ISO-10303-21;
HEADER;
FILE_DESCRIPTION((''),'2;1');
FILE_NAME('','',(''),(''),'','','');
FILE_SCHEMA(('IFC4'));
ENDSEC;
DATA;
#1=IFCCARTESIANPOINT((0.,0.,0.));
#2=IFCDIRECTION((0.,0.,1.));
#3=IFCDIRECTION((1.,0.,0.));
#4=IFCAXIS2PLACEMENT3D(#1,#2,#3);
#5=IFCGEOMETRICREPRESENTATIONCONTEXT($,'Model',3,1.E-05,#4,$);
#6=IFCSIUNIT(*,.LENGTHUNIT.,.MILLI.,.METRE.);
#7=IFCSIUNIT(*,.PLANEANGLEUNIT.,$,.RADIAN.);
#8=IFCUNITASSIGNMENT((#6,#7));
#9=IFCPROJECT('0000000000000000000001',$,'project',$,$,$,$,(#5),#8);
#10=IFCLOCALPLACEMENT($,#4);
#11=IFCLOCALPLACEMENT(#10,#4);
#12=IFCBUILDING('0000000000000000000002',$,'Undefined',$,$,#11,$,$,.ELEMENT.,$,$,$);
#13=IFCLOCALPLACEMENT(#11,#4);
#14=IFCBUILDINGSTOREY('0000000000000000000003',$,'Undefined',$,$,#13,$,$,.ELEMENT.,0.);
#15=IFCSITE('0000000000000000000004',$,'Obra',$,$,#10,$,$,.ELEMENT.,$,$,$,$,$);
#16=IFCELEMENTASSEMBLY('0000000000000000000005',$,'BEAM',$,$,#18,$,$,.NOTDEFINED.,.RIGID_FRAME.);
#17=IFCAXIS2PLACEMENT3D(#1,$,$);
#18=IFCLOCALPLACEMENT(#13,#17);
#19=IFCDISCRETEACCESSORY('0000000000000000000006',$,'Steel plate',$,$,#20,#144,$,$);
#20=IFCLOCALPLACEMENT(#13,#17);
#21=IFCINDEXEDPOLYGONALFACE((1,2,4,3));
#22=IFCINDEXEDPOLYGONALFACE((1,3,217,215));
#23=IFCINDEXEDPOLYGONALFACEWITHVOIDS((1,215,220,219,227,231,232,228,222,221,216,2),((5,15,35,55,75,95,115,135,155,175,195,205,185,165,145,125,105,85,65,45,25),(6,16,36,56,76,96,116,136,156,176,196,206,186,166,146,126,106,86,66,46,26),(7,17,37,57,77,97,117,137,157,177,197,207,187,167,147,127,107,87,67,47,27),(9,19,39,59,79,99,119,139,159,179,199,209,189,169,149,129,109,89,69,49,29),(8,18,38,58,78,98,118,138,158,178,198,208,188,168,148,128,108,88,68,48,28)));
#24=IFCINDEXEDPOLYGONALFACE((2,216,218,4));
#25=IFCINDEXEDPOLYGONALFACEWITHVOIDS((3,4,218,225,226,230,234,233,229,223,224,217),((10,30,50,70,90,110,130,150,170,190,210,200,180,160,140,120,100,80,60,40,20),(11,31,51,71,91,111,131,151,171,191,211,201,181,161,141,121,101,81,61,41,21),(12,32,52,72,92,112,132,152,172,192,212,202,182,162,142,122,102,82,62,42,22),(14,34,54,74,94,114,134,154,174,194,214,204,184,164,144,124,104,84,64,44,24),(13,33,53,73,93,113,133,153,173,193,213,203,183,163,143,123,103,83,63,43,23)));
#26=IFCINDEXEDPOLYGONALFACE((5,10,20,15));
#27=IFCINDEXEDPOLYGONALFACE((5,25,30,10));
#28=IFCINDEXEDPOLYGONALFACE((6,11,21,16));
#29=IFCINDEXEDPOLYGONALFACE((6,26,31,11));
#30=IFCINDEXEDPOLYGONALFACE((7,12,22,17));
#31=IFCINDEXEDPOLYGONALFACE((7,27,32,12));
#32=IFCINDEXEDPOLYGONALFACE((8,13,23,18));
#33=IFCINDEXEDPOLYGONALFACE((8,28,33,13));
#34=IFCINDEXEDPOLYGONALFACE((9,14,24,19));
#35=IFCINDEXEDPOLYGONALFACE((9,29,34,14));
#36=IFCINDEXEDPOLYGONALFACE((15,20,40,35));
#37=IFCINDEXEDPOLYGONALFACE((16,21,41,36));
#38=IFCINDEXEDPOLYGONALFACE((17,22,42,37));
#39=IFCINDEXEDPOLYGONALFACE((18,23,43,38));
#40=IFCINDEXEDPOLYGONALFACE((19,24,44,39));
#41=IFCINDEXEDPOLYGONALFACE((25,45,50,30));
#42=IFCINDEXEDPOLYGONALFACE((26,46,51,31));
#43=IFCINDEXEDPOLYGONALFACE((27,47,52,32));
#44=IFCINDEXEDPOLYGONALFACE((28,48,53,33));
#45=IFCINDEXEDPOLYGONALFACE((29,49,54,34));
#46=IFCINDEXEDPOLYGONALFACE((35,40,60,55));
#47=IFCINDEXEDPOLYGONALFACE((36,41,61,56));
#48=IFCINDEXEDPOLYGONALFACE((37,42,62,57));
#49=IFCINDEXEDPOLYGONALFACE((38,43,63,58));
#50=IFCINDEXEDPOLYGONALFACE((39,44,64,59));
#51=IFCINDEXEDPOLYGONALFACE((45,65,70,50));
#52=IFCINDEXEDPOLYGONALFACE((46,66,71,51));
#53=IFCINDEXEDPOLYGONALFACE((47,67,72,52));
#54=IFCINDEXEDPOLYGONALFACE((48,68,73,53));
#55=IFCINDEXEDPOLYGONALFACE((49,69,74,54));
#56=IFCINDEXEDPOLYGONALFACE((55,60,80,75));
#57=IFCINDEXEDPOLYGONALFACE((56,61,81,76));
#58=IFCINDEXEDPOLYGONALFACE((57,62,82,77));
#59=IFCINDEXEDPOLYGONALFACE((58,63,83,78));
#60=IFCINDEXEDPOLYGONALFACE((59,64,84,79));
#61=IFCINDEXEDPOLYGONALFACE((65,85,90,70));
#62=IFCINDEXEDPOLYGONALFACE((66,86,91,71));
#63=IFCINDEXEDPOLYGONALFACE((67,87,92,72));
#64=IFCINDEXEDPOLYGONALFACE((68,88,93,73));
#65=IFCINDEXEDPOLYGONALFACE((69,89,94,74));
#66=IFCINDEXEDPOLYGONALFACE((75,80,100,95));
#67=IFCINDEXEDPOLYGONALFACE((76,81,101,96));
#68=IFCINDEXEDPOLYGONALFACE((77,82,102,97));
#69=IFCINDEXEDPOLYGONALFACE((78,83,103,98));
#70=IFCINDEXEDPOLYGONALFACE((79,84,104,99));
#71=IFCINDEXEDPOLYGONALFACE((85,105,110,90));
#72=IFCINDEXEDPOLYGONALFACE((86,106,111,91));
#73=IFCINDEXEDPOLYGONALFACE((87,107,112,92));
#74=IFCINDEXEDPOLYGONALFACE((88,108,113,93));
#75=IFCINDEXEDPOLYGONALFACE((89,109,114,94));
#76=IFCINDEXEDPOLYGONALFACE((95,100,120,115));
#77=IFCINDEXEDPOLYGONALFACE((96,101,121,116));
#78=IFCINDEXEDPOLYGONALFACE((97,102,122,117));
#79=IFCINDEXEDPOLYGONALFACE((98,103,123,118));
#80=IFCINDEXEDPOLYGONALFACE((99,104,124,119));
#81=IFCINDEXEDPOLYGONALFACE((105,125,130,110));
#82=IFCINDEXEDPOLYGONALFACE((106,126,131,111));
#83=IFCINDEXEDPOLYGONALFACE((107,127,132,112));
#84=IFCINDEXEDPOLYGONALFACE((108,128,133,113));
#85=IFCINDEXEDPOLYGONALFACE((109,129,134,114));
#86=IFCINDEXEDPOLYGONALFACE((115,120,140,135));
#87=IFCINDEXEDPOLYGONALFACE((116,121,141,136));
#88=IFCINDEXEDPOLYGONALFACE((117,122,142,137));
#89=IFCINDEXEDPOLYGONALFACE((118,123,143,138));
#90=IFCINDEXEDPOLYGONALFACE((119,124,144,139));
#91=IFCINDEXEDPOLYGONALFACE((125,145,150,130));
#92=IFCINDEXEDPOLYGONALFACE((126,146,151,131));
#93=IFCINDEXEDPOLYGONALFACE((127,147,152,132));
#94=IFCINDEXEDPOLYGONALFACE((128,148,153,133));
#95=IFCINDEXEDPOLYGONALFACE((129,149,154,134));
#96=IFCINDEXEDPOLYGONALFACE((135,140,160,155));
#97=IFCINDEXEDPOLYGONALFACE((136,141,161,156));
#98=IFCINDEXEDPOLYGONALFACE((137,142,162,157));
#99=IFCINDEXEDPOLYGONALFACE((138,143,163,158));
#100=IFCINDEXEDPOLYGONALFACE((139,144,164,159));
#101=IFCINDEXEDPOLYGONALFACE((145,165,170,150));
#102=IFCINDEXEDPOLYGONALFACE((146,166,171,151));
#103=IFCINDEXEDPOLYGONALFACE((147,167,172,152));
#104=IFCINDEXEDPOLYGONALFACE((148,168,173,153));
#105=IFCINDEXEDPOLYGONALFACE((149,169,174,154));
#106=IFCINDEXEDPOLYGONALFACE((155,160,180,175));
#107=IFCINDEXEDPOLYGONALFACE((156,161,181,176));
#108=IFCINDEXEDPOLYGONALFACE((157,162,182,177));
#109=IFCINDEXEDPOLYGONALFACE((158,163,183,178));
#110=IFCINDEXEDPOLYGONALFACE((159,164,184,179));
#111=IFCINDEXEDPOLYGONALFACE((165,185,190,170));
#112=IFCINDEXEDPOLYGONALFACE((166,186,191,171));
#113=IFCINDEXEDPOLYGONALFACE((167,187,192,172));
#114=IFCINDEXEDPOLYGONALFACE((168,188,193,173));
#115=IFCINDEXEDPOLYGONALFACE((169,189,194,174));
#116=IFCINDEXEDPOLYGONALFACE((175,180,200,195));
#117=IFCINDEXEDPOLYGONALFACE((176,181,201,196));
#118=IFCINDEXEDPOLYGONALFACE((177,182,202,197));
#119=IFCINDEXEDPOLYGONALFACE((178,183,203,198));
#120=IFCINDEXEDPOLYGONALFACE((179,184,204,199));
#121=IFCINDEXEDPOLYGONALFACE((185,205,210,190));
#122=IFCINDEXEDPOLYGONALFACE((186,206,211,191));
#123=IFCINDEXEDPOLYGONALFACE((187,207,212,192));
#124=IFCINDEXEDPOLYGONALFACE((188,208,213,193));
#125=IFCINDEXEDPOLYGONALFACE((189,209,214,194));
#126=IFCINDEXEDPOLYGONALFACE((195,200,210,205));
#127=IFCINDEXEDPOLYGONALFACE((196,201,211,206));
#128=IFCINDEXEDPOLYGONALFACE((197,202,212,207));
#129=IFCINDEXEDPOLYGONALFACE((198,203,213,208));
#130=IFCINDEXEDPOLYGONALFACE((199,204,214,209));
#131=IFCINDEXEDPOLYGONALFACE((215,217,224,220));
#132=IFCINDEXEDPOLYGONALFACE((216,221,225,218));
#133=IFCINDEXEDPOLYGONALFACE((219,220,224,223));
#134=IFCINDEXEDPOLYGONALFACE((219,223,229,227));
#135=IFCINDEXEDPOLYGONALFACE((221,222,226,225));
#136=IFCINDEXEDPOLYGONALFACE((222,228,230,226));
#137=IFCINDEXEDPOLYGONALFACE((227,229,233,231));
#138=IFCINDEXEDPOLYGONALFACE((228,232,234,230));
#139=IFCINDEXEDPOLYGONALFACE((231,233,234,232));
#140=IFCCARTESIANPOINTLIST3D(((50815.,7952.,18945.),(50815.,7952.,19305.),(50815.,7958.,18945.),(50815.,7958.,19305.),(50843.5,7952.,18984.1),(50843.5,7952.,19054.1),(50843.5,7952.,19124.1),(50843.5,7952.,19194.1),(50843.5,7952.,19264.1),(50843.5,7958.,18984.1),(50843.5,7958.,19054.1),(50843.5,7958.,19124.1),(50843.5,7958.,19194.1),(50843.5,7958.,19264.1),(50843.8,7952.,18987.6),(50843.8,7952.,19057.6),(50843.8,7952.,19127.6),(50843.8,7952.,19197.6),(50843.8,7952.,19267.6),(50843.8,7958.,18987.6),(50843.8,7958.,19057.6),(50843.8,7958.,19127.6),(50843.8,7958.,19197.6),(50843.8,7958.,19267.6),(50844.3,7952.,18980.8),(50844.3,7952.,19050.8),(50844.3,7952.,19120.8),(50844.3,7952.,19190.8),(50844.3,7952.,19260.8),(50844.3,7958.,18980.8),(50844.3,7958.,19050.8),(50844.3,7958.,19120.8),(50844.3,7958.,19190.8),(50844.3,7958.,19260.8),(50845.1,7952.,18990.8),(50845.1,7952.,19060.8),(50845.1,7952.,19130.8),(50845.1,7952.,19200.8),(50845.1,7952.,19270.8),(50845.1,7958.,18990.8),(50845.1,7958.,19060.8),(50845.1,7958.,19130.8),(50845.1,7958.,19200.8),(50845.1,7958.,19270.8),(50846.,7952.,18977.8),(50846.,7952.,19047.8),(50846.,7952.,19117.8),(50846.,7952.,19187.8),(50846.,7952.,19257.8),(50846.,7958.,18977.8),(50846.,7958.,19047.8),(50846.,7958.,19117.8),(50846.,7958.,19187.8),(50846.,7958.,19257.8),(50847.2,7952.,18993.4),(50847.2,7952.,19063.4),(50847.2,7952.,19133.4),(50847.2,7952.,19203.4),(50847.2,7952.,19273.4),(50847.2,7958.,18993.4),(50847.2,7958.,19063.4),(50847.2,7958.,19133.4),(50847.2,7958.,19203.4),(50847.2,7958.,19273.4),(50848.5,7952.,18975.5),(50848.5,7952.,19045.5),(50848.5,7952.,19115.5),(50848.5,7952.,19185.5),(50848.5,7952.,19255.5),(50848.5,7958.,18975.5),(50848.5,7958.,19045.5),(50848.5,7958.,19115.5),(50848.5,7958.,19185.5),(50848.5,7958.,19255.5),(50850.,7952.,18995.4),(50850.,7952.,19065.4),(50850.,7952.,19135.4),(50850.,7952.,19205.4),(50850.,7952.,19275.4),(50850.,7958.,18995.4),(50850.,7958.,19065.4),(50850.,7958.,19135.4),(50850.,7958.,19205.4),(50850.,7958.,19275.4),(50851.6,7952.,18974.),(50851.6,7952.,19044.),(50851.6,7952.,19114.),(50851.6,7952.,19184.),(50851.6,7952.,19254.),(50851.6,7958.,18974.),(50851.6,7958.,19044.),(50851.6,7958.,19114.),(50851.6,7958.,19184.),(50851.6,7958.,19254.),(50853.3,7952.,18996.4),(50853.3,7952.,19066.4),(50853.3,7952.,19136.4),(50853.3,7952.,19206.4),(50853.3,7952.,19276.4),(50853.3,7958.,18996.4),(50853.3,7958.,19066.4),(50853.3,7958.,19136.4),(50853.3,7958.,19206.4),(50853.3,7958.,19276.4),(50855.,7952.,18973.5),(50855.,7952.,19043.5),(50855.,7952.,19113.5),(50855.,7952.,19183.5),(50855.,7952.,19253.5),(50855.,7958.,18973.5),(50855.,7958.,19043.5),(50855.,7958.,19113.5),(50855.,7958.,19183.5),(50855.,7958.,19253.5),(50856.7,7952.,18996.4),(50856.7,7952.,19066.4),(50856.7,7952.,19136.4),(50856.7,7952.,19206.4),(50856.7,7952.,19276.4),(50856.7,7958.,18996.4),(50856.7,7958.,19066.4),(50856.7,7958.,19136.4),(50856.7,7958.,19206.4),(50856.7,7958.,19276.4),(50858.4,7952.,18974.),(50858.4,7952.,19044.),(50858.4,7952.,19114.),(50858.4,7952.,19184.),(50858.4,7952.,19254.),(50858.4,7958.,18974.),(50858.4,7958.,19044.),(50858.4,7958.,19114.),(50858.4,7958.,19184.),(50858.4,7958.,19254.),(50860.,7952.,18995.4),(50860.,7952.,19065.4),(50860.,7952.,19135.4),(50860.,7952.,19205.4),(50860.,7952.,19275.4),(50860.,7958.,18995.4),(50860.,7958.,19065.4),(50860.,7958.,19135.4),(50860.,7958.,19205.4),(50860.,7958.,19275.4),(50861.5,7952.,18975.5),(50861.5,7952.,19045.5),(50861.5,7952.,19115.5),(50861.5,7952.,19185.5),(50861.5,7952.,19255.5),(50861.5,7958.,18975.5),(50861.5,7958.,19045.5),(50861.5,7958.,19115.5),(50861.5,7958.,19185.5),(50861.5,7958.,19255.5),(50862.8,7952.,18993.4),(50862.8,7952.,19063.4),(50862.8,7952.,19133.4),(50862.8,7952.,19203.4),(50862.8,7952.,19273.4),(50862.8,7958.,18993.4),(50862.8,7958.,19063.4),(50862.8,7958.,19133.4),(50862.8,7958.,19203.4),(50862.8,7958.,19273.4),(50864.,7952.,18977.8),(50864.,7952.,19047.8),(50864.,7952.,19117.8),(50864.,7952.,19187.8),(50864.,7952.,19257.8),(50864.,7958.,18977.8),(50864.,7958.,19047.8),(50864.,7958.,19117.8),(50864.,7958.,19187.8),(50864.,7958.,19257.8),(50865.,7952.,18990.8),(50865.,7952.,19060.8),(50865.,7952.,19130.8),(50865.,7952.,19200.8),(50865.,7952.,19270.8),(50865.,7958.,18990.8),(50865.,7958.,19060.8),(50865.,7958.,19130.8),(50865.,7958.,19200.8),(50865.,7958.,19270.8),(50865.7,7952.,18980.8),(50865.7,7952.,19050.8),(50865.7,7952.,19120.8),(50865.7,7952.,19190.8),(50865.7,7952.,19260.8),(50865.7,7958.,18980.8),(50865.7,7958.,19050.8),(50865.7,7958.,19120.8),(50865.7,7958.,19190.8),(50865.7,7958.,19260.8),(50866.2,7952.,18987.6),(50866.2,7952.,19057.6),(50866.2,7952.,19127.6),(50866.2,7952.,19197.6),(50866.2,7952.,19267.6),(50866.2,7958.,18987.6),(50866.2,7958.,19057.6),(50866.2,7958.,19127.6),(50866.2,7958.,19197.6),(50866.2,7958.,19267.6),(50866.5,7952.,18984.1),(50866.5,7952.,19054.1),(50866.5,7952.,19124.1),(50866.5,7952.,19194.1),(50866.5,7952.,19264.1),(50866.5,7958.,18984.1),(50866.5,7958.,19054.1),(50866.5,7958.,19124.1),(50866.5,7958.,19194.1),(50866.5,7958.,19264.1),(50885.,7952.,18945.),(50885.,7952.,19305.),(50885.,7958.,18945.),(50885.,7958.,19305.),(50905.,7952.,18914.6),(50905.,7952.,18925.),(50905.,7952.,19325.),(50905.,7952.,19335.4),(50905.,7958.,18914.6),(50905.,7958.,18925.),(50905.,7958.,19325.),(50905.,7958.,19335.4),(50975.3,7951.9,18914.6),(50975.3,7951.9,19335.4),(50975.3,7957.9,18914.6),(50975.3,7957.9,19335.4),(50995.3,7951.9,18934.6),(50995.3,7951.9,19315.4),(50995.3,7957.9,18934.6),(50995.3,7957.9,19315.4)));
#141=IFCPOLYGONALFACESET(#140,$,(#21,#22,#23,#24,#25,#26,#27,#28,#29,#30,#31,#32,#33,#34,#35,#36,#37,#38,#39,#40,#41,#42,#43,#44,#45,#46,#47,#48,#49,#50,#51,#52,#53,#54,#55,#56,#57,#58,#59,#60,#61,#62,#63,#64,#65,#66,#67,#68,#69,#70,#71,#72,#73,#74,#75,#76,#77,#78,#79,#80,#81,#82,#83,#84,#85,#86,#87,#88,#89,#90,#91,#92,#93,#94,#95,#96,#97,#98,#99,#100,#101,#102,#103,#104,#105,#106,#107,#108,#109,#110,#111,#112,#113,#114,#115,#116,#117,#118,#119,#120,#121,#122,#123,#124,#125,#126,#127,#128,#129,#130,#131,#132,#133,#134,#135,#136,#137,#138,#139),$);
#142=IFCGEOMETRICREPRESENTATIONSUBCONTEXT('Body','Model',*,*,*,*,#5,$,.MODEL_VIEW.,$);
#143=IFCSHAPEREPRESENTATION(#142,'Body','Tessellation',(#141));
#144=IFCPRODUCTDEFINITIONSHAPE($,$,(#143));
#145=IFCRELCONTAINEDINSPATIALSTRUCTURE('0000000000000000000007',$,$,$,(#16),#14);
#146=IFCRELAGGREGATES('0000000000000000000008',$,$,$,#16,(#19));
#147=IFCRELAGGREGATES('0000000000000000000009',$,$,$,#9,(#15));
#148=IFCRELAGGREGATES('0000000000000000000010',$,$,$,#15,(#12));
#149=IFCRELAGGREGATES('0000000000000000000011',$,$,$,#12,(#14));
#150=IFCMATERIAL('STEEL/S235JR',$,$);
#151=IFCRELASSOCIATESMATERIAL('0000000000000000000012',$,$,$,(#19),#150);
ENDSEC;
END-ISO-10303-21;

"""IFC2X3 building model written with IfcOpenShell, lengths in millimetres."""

from ifc_helpers import new_model, si_unit, frame, origin_with_axes, origin_2d_with_axis, place, context, subcontext, project, spatial, polyline, circle, outline, extrude, source, transform, mapped, material, element, aggregate, save


model = new_model("IFC2X3")

# Units and contexts
model_context = context("Model", 3, precision=1e-05, world=origin_with_axes())
body_context = subcontext(model_context, "Body", "Model", "MODEL_VIEW")
ifc_project = project(units=[si_unit("LENGTHUNIT", "METRE", prefix="MILLI"), si_unit("PLANEANGLEUNIT", "RADIAN")], contexts=[model_context])

# Site, building, storey
site_placement = place(None, origin_with_axes())
site = spatial("IfcSite", under=ifc_project, at=site_placement, Name="Obra", CompositionType="ELEMENT")
building_placement = place(site_placement, origin_with_axes())
building = spatial("IfcBuilding", under=site, at=building_placement, Name="Undefined", CompositionType="ELEMENT")
storey_placement = place(building_placement, origin_with_axes())
storey = spatial("IfcBuildingStorey", under=building, at=storey_placement, Name="Undefined", CompositionType="ELEMENT", Elevation=0.0)

# Shared definitions
ifc_material_1 = material(Name="STEEL/S235JR")

# Element assembly
assembly_1_placement = place(storey_placement, origin_with_axes())
assembly_1 = element("IfcElementAssembly", 1, at=assembly_1_placement, inside=storey, Name="BEAM", AssemblyPlace="NOTDEFINED", PredefinedType="RIGID_FRAME")

# Discrete accessory, opening
discrete_accessory_1_placement = place(assembly_1_placement, frame((50995.3, 7954.9, 18934.6), z_axis=(0.000183, 1.0, 0.0), x_axis=(-0.707107, 0.00013, -0.707107)))
discrete_accessory_1 = element("IfcDiscreteAccessory", 2, at=discrete_accessory_1_placement, material=ifc_material_1, Name="Steel plate", context=body_context, shape_type="SweptSolid", body=[
    extrude(outline(polyline([(0.0, 0.0), (28.3, 0.0), (78.0, 49.7), (70.6, 57.1), (70.6, 85.3), (120.1, 134.8), (-134.4, 389.4), (-183.9, 339.9), (-212.2, 339.9), (-219.6, 347.3), (-269.3, 297.6), (-269.3, 269.3), (0.0, 0.0)])), frame((0.0, 0.0, -3.0), z_axis=(0.0, 0.0, 1.0), x_axis=(1.0, 0.0, 0.0)), (0.0, 0.0, 1.0), 6.0),
])
shared_shape_1 = source(origin_with_axes(), body_context, "Body", "SweptSolid", [
    extrude(circle(Radius=11.5, at=origin_2d_with_axis()), frame((0.0, 4.6, 0.0), z_axis=(0.0, 1.0, 0.0), x_axis=(1.0, 0.0, 0.0)), (0.0, 0.0, 1.0), 6.2),
])
opening_1_placement = place(assembly_1_placement, frame((50895.0, 7962.7, 19305.0), z_axis=(-1.0, 0.000183, 0.0), x_axis=(0.0, 0.0, -1.0)))
element("IfcOpeningElement", 3, at=opening_1_placement, cuts=discrete_accessory_1, ObjectType="Opening", context=body_context, shape_type="MappedRepresentation", body=[
    mapped(shared_shape_1, transform((40.0, 0.0, 40.0))),
    mapped(shared_shape_1, transform((110.0, 0.0, 40.0))),
    mapped(shared_shape_1, transform((180.0, 0.0, 40.0))),
    mapped(shared_shape_1, transform((250.0, 0.0, 40.0))),
    mapped(shared_shape_1, transform((320.0, 0.0, 40.0))),
])
aggregate(assembly_1, [discrete_accessory_1])

save(model, "model.ifc")
